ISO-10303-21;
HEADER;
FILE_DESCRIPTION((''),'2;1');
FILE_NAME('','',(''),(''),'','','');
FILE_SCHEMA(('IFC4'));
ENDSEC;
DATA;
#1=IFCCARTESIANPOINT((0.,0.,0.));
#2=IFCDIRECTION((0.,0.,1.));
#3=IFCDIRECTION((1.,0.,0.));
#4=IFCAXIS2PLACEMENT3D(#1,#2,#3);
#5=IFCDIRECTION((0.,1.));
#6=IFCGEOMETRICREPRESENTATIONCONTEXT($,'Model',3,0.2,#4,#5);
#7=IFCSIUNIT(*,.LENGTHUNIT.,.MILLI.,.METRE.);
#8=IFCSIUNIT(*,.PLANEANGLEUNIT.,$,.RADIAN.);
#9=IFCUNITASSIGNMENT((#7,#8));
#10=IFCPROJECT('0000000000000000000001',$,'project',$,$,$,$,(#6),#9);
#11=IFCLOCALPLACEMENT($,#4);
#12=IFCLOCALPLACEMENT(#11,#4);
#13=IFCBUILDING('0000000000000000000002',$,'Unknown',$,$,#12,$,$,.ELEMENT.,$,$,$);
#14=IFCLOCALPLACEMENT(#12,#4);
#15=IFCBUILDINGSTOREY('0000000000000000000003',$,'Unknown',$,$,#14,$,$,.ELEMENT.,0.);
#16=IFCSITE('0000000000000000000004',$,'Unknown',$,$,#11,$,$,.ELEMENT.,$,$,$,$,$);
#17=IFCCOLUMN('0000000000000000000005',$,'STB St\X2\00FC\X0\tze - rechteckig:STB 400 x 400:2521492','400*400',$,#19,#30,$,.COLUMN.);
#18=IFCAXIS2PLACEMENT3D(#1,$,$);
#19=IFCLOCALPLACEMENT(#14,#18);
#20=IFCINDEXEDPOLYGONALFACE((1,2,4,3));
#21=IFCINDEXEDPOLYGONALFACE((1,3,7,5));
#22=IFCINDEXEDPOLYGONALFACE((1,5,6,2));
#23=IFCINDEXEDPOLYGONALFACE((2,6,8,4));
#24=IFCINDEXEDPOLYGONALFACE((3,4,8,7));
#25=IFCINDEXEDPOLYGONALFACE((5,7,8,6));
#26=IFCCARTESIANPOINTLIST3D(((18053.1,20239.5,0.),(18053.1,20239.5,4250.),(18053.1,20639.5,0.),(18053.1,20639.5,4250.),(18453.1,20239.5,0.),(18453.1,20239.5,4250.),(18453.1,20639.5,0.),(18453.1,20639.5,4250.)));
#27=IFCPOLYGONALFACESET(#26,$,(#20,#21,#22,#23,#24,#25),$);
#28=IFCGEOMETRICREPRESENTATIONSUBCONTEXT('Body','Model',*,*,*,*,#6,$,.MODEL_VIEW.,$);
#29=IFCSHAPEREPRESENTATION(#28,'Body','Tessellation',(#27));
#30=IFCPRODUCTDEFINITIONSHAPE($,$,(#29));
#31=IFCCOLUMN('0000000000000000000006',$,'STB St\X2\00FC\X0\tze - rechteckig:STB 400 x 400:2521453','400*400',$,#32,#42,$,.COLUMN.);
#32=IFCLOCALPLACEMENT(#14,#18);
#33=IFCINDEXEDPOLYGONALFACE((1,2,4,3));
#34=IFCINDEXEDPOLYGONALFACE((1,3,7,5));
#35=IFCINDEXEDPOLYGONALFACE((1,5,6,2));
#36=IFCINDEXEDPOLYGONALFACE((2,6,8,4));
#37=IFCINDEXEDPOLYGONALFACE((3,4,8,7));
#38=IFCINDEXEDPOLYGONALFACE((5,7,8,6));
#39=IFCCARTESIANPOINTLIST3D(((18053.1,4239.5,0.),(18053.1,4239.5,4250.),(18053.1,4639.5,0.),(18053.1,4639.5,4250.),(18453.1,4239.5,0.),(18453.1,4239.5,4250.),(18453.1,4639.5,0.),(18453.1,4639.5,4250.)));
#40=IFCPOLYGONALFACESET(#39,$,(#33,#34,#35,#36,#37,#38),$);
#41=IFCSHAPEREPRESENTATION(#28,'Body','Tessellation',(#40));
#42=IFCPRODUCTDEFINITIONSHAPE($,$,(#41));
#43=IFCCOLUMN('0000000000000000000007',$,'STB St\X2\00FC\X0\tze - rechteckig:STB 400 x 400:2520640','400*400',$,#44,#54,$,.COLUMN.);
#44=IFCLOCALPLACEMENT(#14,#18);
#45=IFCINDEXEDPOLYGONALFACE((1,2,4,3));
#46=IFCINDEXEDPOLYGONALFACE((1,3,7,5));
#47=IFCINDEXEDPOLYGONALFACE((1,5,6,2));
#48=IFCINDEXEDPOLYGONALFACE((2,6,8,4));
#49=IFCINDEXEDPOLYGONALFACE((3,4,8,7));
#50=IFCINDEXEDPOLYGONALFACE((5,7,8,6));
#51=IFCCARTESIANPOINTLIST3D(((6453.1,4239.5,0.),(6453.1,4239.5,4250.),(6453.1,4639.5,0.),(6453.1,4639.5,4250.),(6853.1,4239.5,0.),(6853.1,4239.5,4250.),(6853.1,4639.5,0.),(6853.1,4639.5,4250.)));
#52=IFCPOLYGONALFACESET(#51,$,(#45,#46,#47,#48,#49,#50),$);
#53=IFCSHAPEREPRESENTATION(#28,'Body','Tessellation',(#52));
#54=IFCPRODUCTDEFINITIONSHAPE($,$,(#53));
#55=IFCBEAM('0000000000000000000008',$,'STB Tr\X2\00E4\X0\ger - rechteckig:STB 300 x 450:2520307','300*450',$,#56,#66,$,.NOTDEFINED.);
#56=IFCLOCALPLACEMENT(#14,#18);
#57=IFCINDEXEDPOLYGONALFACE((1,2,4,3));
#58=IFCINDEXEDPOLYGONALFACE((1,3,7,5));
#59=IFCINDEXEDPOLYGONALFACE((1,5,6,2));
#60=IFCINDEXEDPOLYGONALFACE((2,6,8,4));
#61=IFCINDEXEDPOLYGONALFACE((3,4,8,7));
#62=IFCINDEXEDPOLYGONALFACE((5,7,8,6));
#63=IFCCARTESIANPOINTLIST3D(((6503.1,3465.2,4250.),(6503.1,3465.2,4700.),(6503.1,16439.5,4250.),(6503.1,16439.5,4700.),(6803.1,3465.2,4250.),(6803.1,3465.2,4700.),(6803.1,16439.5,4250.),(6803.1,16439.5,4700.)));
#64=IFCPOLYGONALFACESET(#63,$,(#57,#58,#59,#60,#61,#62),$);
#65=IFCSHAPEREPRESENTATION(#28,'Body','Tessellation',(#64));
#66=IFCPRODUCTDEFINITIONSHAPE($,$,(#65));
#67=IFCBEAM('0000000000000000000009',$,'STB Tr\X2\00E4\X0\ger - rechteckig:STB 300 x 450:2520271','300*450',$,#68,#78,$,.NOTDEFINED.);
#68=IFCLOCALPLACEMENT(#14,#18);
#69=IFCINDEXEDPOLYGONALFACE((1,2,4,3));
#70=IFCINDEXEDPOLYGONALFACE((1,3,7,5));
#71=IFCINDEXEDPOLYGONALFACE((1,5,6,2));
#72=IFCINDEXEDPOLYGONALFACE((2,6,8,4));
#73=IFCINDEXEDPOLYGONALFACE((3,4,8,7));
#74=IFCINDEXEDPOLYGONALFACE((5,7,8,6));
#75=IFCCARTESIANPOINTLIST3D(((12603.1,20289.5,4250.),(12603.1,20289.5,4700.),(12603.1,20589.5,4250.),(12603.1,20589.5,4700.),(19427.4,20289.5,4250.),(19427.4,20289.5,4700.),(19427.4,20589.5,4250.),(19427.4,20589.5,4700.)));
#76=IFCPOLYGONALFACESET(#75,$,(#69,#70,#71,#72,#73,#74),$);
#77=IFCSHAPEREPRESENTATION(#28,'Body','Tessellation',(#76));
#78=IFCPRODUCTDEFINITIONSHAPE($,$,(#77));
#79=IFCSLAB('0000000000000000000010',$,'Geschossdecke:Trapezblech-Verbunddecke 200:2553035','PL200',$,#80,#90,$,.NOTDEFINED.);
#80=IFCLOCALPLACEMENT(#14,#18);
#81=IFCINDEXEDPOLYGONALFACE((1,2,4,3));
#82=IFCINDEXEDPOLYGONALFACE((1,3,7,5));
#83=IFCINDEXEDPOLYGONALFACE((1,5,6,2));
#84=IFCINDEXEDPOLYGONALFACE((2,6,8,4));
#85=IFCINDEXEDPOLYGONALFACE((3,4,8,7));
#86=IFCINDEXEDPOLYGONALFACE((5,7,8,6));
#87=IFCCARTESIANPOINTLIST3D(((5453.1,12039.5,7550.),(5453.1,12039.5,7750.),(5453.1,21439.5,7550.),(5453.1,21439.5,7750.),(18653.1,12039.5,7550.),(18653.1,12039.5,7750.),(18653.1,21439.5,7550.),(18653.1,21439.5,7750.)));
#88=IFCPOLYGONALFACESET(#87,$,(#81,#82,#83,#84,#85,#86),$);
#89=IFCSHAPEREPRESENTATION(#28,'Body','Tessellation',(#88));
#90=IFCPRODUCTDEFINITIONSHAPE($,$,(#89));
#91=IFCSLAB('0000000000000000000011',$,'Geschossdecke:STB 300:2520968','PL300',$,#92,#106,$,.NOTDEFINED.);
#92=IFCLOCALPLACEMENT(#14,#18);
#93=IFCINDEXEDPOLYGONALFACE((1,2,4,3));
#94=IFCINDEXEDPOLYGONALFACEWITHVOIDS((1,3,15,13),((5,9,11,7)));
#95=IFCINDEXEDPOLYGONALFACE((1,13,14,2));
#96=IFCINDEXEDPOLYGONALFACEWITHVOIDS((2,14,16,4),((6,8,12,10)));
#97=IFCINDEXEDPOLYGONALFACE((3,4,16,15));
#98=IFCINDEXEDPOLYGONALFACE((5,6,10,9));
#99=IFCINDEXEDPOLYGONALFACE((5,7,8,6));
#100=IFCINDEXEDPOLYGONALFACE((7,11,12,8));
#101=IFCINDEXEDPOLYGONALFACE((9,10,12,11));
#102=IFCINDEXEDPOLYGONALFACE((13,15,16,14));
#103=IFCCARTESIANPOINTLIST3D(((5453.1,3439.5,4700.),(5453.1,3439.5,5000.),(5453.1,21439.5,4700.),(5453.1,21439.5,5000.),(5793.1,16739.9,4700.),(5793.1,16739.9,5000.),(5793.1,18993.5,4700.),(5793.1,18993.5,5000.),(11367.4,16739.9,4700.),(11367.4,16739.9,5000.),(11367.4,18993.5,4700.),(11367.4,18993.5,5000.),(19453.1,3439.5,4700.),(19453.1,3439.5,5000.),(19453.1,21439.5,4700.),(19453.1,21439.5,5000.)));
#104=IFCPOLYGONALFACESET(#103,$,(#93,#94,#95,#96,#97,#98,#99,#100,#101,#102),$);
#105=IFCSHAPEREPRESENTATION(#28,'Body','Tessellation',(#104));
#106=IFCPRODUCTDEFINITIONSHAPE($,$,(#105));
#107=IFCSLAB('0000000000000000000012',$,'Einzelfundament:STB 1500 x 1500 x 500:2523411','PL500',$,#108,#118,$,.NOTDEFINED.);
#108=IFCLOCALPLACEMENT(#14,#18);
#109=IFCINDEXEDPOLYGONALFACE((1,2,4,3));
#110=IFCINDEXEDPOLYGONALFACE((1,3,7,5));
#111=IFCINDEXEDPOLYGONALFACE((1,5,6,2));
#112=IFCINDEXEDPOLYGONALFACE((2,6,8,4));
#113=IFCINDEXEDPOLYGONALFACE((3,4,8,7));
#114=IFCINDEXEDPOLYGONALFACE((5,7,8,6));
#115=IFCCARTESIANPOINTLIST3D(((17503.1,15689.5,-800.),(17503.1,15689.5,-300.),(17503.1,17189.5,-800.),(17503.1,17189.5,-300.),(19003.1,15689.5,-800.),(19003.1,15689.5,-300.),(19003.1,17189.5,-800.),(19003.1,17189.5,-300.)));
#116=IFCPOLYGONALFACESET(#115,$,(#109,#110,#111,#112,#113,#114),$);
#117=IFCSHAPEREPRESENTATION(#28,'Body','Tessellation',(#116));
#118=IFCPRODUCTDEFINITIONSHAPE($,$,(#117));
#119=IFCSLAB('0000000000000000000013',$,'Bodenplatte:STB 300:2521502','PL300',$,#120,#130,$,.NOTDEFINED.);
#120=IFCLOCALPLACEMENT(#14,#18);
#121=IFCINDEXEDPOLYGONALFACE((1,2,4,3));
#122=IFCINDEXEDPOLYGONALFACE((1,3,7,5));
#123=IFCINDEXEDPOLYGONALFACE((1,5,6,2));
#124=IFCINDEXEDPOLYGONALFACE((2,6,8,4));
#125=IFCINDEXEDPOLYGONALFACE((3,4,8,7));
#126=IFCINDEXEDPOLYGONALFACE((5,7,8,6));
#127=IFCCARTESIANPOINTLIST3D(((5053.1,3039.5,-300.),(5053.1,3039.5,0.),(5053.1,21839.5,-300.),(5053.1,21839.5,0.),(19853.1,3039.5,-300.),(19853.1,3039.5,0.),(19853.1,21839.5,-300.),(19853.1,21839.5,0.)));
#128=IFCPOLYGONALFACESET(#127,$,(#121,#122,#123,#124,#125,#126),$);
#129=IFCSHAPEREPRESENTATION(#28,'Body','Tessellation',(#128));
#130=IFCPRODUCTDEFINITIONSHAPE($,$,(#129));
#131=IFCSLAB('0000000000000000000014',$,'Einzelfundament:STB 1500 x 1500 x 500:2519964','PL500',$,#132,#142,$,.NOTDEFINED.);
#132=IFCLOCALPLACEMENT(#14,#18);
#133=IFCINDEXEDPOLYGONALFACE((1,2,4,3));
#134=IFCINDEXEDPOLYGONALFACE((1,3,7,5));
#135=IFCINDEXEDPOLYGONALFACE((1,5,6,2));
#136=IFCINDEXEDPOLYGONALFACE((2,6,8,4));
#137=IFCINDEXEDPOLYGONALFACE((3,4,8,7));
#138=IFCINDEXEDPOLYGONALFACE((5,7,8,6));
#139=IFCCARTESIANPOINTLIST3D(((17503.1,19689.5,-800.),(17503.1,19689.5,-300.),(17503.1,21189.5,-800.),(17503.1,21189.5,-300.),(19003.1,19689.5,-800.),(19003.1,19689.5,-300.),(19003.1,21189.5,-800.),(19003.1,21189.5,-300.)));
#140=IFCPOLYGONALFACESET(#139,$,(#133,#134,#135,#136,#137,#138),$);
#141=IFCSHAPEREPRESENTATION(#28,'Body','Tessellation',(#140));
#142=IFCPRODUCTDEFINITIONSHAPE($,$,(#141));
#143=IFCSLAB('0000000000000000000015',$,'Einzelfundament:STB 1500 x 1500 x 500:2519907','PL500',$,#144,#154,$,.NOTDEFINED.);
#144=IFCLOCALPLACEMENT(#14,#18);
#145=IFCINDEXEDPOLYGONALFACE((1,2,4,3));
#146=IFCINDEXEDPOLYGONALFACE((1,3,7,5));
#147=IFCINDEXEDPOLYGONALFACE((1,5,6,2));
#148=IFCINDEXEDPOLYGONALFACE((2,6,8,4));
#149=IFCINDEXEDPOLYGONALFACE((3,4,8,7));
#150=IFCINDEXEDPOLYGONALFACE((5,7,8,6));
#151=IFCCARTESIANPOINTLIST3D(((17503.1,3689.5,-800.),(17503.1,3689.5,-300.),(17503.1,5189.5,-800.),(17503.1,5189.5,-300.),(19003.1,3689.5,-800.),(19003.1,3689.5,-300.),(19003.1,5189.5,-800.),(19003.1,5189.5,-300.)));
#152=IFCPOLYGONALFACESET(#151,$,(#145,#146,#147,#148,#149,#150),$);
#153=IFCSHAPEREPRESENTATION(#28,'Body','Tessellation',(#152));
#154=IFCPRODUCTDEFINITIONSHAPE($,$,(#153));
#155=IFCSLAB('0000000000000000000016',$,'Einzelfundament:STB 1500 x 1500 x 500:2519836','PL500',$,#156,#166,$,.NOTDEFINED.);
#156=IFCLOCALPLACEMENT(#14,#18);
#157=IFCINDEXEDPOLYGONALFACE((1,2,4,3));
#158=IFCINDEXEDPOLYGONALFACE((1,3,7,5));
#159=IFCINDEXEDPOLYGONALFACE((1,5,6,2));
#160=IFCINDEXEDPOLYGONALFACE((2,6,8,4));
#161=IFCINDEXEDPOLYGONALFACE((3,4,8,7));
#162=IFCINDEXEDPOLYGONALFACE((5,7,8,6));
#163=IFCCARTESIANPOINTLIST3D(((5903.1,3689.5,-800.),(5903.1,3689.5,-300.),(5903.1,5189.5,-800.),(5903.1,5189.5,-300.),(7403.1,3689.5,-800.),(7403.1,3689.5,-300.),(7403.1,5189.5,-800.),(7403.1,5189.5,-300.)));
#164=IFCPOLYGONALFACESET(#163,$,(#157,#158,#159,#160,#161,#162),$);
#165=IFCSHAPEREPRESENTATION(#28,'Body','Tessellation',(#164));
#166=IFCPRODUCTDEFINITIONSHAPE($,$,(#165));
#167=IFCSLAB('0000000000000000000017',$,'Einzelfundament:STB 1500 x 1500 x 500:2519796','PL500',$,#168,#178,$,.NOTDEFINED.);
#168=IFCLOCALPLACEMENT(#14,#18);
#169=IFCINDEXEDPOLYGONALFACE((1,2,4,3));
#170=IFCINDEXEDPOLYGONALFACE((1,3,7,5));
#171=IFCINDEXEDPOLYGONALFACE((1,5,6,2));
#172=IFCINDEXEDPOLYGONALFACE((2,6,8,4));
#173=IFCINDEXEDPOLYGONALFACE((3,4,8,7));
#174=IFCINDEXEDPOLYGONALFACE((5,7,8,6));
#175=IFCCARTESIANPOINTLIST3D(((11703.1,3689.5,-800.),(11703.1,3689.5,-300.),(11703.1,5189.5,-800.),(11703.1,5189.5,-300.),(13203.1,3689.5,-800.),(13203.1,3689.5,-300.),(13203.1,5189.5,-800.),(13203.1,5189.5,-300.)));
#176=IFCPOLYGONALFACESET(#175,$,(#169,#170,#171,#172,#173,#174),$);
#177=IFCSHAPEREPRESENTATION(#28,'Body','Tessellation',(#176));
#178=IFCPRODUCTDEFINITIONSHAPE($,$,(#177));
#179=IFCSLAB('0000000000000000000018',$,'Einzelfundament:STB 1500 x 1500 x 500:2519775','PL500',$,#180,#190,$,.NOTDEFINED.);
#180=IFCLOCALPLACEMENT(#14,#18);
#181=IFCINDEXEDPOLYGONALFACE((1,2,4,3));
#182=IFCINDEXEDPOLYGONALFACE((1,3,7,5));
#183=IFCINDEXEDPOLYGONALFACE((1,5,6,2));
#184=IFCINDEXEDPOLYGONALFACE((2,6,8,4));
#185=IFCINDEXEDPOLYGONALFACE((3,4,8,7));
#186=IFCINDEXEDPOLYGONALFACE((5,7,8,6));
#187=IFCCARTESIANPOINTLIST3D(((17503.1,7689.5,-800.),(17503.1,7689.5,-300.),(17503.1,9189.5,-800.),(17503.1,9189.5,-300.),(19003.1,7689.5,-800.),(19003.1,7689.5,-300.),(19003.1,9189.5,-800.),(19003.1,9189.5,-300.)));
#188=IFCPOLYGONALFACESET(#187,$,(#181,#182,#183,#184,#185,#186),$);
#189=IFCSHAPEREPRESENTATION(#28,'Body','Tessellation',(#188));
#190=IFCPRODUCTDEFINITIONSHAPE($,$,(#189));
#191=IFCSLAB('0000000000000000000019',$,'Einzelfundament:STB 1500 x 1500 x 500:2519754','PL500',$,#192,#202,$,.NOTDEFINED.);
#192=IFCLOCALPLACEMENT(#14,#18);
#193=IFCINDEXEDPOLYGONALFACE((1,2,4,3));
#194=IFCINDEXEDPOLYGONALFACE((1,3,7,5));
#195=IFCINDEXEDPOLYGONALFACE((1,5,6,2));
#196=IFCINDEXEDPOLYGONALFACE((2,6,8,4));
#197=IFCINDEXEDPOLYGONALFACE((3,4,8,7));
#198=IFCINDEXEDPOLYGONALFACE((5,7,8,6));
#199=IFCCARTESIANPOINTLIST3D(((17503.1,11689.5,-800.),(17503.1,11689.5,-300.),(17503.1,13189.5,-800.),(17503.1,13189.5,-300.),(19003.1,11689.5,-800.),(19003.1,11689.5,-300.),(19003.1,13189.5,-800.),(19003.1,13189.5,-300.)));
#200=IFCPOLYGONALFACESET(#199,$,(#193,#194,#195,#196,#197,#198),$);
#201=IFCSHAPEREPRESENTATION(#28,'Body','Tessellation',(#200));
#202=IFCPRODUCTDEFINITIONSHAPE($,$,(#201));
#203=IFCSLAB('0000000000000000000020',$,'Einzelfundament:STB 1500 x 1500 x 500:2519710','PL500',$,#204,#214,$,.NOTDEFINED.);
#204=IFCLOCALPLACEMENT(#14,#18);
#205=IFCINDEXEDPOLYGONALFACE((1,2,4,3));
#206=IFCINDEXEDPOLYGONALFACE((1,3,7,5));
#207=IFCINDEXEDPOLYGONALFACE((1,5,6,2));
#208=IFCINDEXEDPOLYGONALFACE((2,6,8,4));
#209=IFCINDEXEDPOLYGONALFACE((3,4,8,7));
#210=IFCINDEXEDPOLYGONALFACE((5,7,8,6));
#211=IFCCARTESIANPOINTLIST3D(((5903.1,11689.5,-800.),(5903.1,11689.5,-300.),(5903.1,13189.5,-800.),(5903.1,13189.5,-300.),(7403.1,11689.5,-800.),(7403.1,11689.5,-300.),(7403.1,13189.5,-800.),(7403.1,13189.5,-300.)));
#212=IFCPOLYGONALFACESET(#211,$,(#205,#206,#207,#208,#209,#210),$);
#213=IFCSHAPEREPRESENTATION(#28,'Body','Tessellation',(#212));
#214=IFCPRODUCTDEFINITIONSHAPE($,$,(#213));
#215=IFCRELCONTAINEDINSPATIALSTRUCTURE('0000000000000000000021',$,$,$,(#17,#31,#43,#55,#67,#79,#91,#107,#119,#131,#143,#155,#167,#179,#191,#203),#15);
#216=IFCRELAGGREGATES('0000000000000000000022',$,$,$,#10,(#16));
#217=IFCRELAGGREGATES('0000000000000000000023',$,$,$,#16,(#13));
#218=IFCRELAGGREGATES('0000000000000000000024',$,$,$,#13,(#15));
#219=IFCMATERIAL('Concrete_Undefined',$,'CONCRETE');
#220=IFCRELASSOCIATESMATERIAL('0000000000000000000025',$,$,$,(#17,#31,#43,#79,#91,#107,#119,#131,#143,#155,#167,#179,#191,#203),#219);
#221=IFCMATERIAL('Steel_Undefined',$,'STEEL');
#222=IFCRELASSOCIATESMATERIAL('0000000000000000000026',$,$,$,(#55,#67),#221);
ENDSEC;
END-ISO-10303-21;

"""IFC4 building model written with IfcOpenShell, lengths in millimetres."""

from ifc_helpers import new_model, si_unit, direction, frame, origin_with_axes, place, context, subcontext, project, spatial, line, indexed_curve, outline, extrude, material, element, save


model = new_model("IFC4")

# Units and contexts
model_context = context("Model", 3, precision=0.2, world=origin_with_axes(), true_north=direction((0.0, 1.0)))
body_context = subcontext(model_context, "Body", "Model", "MODEL_VIEW")
ifc_project = project(units=[si_unit("LENGTHUNIT", "METRE", prefix="MILLI"), si_unit("PLANEANGLEUNIT", "RADIAN")], contexts=[model_context])

# Site, building, storey
site_placement = place(None, origin_with_axes())
site = spatial("IfcSite", under=ifc_project, at=site_placement, Name="Unknown", CompositionType="ELEMENT")
building_placement = place(site_placement, origin_with_axes())
building = spatial("IfcBuilding", under=site, at=building_placement, Name="Unknown", CompositionType="ELEMENT")
storey_placement = place(building_placement, origin_with_axes())
storey = spatial("IfcBuildingStorey", under=building, at=storey_placement, Name="Unknown", CompositionType="ELEMENT", Elevation=0.0)

# Columns
ifc_material_1 = material(Name="Concrete_Undefined", Category="CONCRETE")
for number, where, z_axis, x_axis, name in (
    (1, (18253.1, 20439.5, 0.0), (1.0, 0.0, 0.0), (0.0, 0.0, 1.0), "STB Stütze - rechteckig:STB 400 x 400:2521492"),
    (2, (18253.1, 4439.5, 0.0), (1.0, 0.0, 0.0), (0.0, 0.0, 1.0), "STB Stütze - rechteckig:STB 400 x 400:2521453"),
    (3, (6653.1, 4439.5, 0.0), (1.0, 0.0, 0.0), (0.0, 0.0, 1.0), "STB Stütze - rechteckig:STB 400 x 400:2520640"),
):
    element("IfcColumn", number, at=place(storey_placement, frame(where, z_axis=z_axis, x_axis=x_axis)), inside=storey, material=ifc_material_1, Name=name, Description="400*400", PredefinedType="COLUMN", context=body_context, shape_type="SolidModel", body=[
        extrude(outline(indexed_curve([(-200.0, -200.0), (200.0, -200.0), (200.0, 200.0), (-200.0, 200.0)], segments=[line(1, 2, 3, 4, 1)])), frame((0.0, 0.0, 0.0), z_axis=(-1.0, 0.0, 0.0), x_axis=(0.0, 0.0, 1.0)), (0.0, 0.0, -1.0), 4250.0),
    ])

# Beams
ifc_material_2 = material(Name="Steel_Undefined", Category="STEEL")
beam_1_placement = place(storey_placement, frame((6653.1, 16439.5, 4475.0), z_axis=(0.0, 0.0, 1.0), x_axis=(0.0, -1.0, 0.0)))
element("IfcBeam", 4, at=beam_1_placement, inside=storey, material=ifc_material_2, Name="STB Träger - rechteckig:STB 300 x 450:2520307", Description="300*450", PredefinedType="NOTDEFINED", context=body_context, shape_type="SolidModel", body=[
    extrude(outline(indexed_curve([(-225.0, -150.0), (225.0, -150.0), (225.0, 150.0), (-225.0, 150.0)], segments=[line(1, 2, 3, 4, 1)])), frame((0.0, 0.0, 0.0), z_axis=(-1.0, 0.0, 0.0), x_axis=(0.0, 0.0, 1.0)), (0.0, 0.0, -1.0), 12974.3),
])
beam_2_placement = place(storey_placement, frame((12603.1, 20439.5, 4475.0), z_axis=(0.0, 0.0, 1.0), x_axis=(1.0, 0.0, 0.0)))
element("IfcBeam", 5, at=beam_2_placement, inside=storey, material=ifc_material_2, Name="STB Träger - rechteckig:STB 300 x 450:2520271", Description="300*450", PredefinedType="NOTDEFINED", context=body_context, shape_type="SolidModel", body=[
    extrude(outline(indexed_curve([(-225.0, -150.0), (225.0, -150.0), (225.0, 150.0), (-225.0, 150.0)], segments=[line(1, 2, 3, 4, 1)])), frame((0.0, 0.0, 0.0), z_axis=(-1.0, 0.0, 0.0), x_axis=(0.0, 0.0, 1.0)), (0.0, 0.0, -1.0), 6824.3),
])

# Slab
slab_1_placement = place(storey_placement, frame((5453.1, 21439.5, 7650.0), z_axis=(0.0, 0.0, 1.0), x_axis=(0.0, -1.0, 0.0)))
element("IfcSlab", 6, at=slab_1_placement, inside=storey, material=ifc_material_1, Name="Geschossdecke:Trapezblech-Verbunddecke 200:2553035", Description="PL200", PredefinedType="NOTDEFINED", context=body_context, shape_type="SolidModel", body=[
    extrude(outline(indexed_curve([(0.0, 0.0), (9400.0, 0.0), (9400.0, 13200.0), (0.0, 13200.0)], segments=[line(1, 2, 3, 4, 1)])), frame((0.0, 0.0, 100.0), z_axis=(0.0, 0.0, 1.0), x_axis=(1.0, 0.0, 0.0)), (0.0, 0.0, -1.0), 200.0),
])

# Slab, voiding feature
slab_2_placement = place(storey_placement, frame((19453.1, 3439.5, 4850.0), z_axis=(0.0, 0.0, 1.0), x_axis=(0.0, 1.0, 0.0)))
slab_2 = element("IfcSlab", 7, at=slab_2_placement, inside=storey, material=ifc_material_1, Name="Geschossdecke:STB 300:2520968", Description="PL300", PredefinedType="NOTDEFINED", context=body_context, shape_type="SolidModel", body=[
    extrude(outline(indexed_curve([(0.0, 0.0), (18000.0, 0.0), (18000.0, 14000.0), (0.0, 14000.0)], segments=[line(1, 2, 3, 4, 1)])), frame((0.0, 0.0, 150.0), z_axis=(0.0, 0.0, 1.0), x_axis=(1.0, 0.0, 0.0)), (0.0, 0.0, -1.0), 300.0),
])
voiding_feature_placement = place(slab_2_placement, frame((14427.2, 10872.8, 150.0), z_axis=(-1.0, 0.0, 0.0), x_axis=(0.0, 0.0, -1.0)))
element("IfcVoidingFeature", 8, at=voiding_feature_placement, cuts=slab_2, Name="Geschossdecke:STB 300:712247", PredefinedType="HOLE", context=body_context, shape_type="SolidModel", body=[
    extrude(outline(indexed_curve([(-1126.8, -2787.2), (1126.8, -2787.2), (1126.8, 2787.2), (-1126.8, 2787.2)], segments=[line(1, 2, 3, 4, 1)])), frame((0.0, 0.0, 0.0), z_axis=(-1.0, 0.0, 0.0), x_axis=(0.0, 0.0, 1.0)), (0.0, 0.0, -1.0), 300.0),
])

# Slabs
slab_3_placement = place(storey_placement, frame((17503.1, 17189.5, -550.0), z_axis=(0.0, 0.0, -1.0), x_axis=(1.0, 0.0, 0.0)))
element("IfcSlab", 9, at=slab_3_placement, inside=storey, material=ifc_material_1, Name="Einzelfundament:STB 1500 x 1500 x 500:2523411", Description="PL500", PredefinedType="NOTDEFINED", context=body_context, shape_type="SolidModel", body=[
    extrude(outline(indexed_curve([(0.0, 0.0), (1500.0, 0.0), (1500.0, 1500.0), (0.0, 1500.0)], segments=[line(1, 2, 3, 4, 1)])), frame((0.0, 0.0, 250.0), z_axis=(0.0, 0.0, 1.0), x_axis=(1.0, 0.0, 0.0)), (0.0, 0.0, -1.0), 500.0),
])
slab_4_placement = place(storey_placement, frame((5053.1, 21839.5, -150.0), z_axis=(0.0, 0.0, 1.0), x_axis=(0.0, -1.0, 0.0)))
element("IfcSlab", 10, at=slab_4_placement, inside=storey, material=ifc_material_1, Name="Bodenplatte:STB 300:2521502", Description="PL300", PredefinedType="NOTDEFINED", context=body_context, shape_type="SolidModel", body=[
    extrude(outline(indexed_curve([(0.0, 0.0), (18800.0, 0.0), (18800.0, 14800.0), (0.0, 14800.0)], segments=[line(1, 2, 3, 4, 1)])), frame((0.0, 0.0, 150.0), z_axis=(0.0, 0.0, 1.0), x_axis=(1.0, 0.0, 0.0)), (0.0, 0.0, -1.0), 300.0),
])
for number, where, z_axis, x_axis, name in (
    (11, (17503.1, 21189.5, -550.0), (0.0, 0.0, -1.0), (1.0, 0.0, 0.0), "Einzelfundament:STB 1500 x 1500 x 500:2519964"),
    (12, (17503.1, 5189.5, -550.0), (0.0, 0.0, -1.0), (1.0, 0.0, 0.0), "Einzelfundament:STB 1500 x 1500 x 500:2519907"),
    (13, (5903.1, 5189.5, -550.0), (0.0, 0.0, -1.0), (1.0, 0.0, 0.0), "Einzelfundament:STB 1500 x 1500 x 500:2519836"),
    (14, (13203.1, 5189.5, -550.0), (0.0, 0.0, -1.0), (0.0, -1.0, 0.0), "Einzelfundament:STB 1500 x 1500 x 500:2519796"),
    (15, (17503.1, 9189.5, -550.0), (0.0, 0.0, -1.0), (1.0, 0.0, 0.0), "Einzelfundament:STB 1500 x 1500 x 500:2519775"),
    (16, (17503.1, 13189.5, -550.0), (0.0, 0.0, -1.0), (1.0, 0.0, 0.0), "Einzelfundament:STB 1500 x 1500 x 500:2519754"),
    (17, (5903.1, 13189.5, -550.0), (0.0, 0.0, -1.0), (1.0, 0.0, 0.0), "Einzelfundament:STB 1500 x 1500 x 500:2519710"),
):
    element("IfcSlab", number, at=place(storey_placement, frame(where, z_axis=z_axis, x_axis=x_axis)), inside=storey, material=ifc_material_1, Name=name, Description="PL500", PredefinedType="NOTDEFINED", context=body_context, shape_type="SolidModel", body=[
        extrude(outline(indexed_curve([(0.0, 0.0), (1500.0, 0.0), (1500.0, 1500.0), (0.0, 1500.0)], segments=[line(1, 2, 3, 4, 1)])), frame((0.0, 0.0, 250.0), z_axis=(0.0, 0.0, 1.0), x_axis=(1.0, 0.0, 0.0)), (0.0, 0.0, -1.0), 500.0),
    ])

save(model, "model.ifc")
